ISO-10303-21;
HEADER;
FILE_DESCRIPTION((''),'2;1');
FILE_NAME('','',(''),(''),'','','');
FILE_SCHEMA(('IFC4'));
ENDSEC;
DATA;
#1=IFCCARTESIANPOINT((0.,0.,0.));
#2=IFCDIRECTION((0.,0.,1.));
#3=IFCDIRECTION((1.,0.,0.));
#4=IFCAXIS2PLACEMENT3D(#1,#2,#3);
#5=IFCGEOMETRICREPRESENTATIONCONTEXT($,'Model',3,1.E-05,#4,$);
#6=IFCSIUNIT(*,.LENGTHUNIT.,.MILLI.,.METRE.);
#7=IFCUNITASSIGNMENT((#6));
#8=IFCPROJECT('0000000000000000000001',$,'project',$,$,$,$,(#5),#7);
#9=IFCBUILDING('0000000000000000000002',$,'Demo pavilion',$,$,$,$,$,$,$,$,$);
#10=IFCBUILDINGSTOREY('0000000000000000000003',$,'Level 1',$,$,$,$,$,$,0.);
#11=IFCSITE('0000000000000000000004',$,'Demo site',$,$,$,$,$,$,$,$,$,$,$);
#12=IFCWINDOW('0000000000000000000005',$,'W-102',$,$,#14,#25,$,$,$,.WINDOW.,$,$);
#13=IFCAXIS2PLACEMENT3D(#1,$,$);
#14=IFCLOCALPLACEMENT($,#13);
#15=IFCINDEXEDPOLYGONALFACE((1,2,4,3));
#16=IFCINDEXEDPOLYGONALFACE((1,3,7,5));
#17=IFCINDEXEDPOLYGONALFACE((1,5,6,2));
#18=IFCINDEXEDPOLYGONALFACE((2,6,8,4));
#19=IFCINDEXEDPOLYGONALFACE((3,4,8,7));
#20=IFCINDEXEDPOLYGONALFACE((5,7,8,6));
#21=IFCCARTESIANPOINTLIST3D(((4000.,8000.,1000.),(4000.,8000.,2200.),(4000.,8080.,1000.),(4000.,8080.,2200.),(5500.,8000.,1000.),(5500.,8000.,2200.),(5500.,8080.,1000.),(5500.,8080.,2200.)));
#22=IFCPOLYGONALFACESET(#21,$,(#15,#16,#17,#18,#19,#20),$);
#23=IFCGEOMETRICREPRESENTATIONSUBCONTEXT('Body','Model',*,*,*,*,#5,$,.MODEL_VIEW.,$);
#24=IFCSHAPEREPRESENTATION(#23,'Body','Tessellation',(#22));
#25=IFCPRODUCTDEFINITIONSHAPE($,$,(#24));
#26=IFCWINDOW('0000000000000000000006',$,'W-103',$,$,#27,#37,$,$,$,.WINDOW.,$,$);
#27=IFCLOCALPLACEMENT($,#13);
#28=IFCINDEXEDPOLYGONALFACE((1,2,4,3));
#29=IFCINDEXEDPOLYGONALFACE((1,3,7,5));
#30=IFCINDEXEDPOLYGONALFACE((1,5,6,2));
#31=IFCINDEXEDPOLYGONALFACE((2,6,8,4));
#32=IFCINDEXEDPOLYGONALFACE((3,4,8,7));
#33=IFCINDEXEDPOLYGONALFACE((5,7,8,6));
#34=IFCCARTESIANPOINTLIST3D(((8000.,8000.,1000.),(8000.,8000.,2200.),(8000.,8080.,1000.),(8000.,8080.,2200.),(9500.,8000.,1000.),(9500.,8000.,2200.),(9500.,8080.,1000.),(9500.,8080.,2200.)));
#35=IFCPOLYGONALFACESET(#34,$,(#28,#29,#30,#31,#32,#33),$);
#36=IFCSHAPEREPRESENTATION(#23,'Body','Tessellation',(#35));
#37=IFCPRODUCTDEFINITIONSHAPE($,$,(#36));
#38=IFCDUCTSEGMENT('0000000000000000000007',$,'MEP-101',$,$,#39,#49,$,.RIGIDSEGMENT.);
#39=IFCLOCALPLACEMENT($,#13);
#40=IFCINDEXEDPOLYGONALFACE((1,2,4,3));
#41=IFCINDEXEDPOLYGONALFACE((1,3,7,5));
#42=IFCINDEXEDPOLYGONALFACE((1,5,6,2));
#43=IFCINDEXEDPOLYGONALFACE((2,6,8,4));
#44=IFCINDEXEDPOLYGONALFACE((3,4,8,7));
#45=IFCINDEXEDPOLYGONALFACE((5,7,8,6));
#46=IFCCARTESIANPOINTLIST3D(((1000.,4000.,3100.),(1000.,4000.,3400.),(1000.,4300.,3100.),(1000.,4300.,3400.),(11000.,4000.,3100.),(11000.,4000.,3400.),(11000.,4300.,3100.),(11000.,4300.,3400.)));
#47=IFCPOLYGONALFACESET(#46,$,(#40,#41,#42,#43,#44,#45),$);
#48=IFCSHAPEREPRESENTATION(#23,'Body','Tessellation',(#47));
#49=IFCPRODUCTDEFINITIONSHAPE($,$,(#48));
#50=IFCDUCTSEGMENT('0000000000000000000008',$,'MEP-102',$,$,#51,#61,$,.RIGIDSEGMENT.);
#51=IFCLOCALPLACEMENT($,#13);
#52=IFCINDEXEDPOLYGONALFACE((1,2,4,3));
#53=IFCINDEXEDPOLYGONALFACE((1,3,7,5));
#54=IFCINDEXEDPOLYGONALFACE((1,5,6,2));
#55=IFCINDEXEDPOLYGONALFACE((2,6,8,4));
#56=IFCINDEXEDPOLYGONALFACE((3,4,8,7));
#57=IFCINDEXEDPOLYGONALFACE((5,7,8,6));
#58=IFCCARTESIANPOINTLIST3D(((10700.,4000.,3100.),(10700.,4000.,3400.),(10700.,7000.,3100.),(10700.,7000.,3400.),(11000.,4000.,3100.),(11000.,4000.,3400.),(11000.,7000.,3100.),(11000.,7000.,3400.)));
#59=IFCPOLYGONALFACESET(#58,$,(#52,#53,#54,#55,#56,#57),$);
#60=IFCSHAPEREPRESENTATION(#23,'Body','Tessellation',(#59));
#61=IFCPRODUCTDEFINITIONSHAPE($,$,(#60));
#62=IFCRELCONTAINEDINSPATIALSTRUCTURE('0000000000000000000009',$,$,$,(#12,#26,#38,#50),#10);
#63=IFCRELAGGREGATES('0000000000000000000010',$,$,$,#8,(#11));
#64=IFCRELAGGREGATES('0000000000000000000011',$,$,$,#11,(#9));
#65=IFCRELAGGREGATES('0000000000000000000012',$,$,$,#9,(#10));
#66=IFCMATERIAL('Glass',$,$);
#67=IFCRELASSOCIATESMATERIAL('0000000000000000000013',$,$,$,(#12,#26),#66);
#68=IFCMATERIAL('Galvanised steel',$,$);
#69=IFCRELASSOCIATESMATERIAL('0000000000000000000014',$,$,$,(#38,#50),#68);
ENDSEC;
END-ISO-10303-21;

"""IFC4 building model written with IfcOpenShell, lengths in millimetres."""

from ifc_helpers import new_model, si_unit, frame, origin_with_axes, place, context, subcontext, project, spatial, indexed_curve, outline, extrude, material, element, save


model = new_model("IFC4")

# Units and contexts
model_context = context("Model", 3, precision=1e-05, world=origin_with_axes())
body_context = subcontext(model_context, "Body", "Model", "MODEL_VIEW")
ifc_project = project(units=[si_unit("LENGTHUNIT", "METRE", prefix="MILLI")], contexts=[model_context])

# Site, building, storey
site = spatial("IfcSite", under=ifc_project, Name="Demo site")
building = spatial("IfcBuilding", under=site, Name="Demo pavilion")
storey = spatial("IfcBuildingStorey", under=building, Name="Level 1", Elevation=0.0)

# Windows
ifc_material_1 = material(Name="Glass")
for number, where, z_axis, x_axis, name in (
    (1, (4000.0, 8000.0, 1000.0), (0.0, 0.0, 1.0), (1.0, 0.0, 0.0), "W-102"),
    (2, (8000.0, 8000.0, 1000.0), (0.0, 0.0, 1.0), (1.0, 0.0, 0.0), "W-103"),
):
    element("IfcWindow", number, at=place(None, frame(where, z_axis=z_axis, x_axis=x_axis)), inside=storey, material=ifc_material_1, Name=name, PredefinedType="WINDOW", context=body_context, shape_type="SweptSolid", body=[
        extrude(outline(indexed_curve([(0.0, 0.0), (0.0, 80.0), (1500.0, 80.0), (1500.0, 0.0), (0.0, 0.0)], self_intersect=False)), origin_with_axes(), (0.0, 0.0, 1.0), 1200.0),
    ])

# Duct segments
ifc_material_2 = material(Name="Galvanised steel")
duct_segment_1_placement = place(None, frame((1000.0, 4000.0, 3100.0), z_axis=(0.0, 0.0, 1.0), x_axis=(1.0, 0.0, 0.0)))
element("IfcDuctSegment", 3, at=duct_segment_1_placement, inside=storey, material=ifc_material_2, Name="MEP-101", PredefinedType="RIGIDSEGMENT", context=body_context, shape_type="SweptSolid", body=[
    extrude(outline(indexed_curve([(0.0, 0.0), (0.0, 300.0), (10000.0, 300.0), (10000.0, 0.0), (0.0, 0.0)], self_intersect=False)), origin_with_axes(), (0.0, 0.0, 1.0), 300.0),
])
duct_segment_2_placement = place(None, frame((11000.0, 4000.0, 3100.0), z_axis=(0.0, 0.0, 1.0), x_axis=(0.0, 1.0, 0.0)))
element("IfcDuctSegment", 4, at=duct_segment_2_placement, inside=storey, material=ifc_material_2, Name="MEP-102", PredefinedType="RIGIDSEGMENT", context=body_context, shape_type="SweptSolid", body=[
    extrude(outline(indexed_curve([(0.0, 0.0), (0.0, 300.0), (3000.0, 300.0), (3000.0, 0.0), (0.0, 0.0)], self_intersect=False)), origin_with_axes(), (0.0, 0.0, 1.0), 300.0),
])

save(model, "model.ifc")
